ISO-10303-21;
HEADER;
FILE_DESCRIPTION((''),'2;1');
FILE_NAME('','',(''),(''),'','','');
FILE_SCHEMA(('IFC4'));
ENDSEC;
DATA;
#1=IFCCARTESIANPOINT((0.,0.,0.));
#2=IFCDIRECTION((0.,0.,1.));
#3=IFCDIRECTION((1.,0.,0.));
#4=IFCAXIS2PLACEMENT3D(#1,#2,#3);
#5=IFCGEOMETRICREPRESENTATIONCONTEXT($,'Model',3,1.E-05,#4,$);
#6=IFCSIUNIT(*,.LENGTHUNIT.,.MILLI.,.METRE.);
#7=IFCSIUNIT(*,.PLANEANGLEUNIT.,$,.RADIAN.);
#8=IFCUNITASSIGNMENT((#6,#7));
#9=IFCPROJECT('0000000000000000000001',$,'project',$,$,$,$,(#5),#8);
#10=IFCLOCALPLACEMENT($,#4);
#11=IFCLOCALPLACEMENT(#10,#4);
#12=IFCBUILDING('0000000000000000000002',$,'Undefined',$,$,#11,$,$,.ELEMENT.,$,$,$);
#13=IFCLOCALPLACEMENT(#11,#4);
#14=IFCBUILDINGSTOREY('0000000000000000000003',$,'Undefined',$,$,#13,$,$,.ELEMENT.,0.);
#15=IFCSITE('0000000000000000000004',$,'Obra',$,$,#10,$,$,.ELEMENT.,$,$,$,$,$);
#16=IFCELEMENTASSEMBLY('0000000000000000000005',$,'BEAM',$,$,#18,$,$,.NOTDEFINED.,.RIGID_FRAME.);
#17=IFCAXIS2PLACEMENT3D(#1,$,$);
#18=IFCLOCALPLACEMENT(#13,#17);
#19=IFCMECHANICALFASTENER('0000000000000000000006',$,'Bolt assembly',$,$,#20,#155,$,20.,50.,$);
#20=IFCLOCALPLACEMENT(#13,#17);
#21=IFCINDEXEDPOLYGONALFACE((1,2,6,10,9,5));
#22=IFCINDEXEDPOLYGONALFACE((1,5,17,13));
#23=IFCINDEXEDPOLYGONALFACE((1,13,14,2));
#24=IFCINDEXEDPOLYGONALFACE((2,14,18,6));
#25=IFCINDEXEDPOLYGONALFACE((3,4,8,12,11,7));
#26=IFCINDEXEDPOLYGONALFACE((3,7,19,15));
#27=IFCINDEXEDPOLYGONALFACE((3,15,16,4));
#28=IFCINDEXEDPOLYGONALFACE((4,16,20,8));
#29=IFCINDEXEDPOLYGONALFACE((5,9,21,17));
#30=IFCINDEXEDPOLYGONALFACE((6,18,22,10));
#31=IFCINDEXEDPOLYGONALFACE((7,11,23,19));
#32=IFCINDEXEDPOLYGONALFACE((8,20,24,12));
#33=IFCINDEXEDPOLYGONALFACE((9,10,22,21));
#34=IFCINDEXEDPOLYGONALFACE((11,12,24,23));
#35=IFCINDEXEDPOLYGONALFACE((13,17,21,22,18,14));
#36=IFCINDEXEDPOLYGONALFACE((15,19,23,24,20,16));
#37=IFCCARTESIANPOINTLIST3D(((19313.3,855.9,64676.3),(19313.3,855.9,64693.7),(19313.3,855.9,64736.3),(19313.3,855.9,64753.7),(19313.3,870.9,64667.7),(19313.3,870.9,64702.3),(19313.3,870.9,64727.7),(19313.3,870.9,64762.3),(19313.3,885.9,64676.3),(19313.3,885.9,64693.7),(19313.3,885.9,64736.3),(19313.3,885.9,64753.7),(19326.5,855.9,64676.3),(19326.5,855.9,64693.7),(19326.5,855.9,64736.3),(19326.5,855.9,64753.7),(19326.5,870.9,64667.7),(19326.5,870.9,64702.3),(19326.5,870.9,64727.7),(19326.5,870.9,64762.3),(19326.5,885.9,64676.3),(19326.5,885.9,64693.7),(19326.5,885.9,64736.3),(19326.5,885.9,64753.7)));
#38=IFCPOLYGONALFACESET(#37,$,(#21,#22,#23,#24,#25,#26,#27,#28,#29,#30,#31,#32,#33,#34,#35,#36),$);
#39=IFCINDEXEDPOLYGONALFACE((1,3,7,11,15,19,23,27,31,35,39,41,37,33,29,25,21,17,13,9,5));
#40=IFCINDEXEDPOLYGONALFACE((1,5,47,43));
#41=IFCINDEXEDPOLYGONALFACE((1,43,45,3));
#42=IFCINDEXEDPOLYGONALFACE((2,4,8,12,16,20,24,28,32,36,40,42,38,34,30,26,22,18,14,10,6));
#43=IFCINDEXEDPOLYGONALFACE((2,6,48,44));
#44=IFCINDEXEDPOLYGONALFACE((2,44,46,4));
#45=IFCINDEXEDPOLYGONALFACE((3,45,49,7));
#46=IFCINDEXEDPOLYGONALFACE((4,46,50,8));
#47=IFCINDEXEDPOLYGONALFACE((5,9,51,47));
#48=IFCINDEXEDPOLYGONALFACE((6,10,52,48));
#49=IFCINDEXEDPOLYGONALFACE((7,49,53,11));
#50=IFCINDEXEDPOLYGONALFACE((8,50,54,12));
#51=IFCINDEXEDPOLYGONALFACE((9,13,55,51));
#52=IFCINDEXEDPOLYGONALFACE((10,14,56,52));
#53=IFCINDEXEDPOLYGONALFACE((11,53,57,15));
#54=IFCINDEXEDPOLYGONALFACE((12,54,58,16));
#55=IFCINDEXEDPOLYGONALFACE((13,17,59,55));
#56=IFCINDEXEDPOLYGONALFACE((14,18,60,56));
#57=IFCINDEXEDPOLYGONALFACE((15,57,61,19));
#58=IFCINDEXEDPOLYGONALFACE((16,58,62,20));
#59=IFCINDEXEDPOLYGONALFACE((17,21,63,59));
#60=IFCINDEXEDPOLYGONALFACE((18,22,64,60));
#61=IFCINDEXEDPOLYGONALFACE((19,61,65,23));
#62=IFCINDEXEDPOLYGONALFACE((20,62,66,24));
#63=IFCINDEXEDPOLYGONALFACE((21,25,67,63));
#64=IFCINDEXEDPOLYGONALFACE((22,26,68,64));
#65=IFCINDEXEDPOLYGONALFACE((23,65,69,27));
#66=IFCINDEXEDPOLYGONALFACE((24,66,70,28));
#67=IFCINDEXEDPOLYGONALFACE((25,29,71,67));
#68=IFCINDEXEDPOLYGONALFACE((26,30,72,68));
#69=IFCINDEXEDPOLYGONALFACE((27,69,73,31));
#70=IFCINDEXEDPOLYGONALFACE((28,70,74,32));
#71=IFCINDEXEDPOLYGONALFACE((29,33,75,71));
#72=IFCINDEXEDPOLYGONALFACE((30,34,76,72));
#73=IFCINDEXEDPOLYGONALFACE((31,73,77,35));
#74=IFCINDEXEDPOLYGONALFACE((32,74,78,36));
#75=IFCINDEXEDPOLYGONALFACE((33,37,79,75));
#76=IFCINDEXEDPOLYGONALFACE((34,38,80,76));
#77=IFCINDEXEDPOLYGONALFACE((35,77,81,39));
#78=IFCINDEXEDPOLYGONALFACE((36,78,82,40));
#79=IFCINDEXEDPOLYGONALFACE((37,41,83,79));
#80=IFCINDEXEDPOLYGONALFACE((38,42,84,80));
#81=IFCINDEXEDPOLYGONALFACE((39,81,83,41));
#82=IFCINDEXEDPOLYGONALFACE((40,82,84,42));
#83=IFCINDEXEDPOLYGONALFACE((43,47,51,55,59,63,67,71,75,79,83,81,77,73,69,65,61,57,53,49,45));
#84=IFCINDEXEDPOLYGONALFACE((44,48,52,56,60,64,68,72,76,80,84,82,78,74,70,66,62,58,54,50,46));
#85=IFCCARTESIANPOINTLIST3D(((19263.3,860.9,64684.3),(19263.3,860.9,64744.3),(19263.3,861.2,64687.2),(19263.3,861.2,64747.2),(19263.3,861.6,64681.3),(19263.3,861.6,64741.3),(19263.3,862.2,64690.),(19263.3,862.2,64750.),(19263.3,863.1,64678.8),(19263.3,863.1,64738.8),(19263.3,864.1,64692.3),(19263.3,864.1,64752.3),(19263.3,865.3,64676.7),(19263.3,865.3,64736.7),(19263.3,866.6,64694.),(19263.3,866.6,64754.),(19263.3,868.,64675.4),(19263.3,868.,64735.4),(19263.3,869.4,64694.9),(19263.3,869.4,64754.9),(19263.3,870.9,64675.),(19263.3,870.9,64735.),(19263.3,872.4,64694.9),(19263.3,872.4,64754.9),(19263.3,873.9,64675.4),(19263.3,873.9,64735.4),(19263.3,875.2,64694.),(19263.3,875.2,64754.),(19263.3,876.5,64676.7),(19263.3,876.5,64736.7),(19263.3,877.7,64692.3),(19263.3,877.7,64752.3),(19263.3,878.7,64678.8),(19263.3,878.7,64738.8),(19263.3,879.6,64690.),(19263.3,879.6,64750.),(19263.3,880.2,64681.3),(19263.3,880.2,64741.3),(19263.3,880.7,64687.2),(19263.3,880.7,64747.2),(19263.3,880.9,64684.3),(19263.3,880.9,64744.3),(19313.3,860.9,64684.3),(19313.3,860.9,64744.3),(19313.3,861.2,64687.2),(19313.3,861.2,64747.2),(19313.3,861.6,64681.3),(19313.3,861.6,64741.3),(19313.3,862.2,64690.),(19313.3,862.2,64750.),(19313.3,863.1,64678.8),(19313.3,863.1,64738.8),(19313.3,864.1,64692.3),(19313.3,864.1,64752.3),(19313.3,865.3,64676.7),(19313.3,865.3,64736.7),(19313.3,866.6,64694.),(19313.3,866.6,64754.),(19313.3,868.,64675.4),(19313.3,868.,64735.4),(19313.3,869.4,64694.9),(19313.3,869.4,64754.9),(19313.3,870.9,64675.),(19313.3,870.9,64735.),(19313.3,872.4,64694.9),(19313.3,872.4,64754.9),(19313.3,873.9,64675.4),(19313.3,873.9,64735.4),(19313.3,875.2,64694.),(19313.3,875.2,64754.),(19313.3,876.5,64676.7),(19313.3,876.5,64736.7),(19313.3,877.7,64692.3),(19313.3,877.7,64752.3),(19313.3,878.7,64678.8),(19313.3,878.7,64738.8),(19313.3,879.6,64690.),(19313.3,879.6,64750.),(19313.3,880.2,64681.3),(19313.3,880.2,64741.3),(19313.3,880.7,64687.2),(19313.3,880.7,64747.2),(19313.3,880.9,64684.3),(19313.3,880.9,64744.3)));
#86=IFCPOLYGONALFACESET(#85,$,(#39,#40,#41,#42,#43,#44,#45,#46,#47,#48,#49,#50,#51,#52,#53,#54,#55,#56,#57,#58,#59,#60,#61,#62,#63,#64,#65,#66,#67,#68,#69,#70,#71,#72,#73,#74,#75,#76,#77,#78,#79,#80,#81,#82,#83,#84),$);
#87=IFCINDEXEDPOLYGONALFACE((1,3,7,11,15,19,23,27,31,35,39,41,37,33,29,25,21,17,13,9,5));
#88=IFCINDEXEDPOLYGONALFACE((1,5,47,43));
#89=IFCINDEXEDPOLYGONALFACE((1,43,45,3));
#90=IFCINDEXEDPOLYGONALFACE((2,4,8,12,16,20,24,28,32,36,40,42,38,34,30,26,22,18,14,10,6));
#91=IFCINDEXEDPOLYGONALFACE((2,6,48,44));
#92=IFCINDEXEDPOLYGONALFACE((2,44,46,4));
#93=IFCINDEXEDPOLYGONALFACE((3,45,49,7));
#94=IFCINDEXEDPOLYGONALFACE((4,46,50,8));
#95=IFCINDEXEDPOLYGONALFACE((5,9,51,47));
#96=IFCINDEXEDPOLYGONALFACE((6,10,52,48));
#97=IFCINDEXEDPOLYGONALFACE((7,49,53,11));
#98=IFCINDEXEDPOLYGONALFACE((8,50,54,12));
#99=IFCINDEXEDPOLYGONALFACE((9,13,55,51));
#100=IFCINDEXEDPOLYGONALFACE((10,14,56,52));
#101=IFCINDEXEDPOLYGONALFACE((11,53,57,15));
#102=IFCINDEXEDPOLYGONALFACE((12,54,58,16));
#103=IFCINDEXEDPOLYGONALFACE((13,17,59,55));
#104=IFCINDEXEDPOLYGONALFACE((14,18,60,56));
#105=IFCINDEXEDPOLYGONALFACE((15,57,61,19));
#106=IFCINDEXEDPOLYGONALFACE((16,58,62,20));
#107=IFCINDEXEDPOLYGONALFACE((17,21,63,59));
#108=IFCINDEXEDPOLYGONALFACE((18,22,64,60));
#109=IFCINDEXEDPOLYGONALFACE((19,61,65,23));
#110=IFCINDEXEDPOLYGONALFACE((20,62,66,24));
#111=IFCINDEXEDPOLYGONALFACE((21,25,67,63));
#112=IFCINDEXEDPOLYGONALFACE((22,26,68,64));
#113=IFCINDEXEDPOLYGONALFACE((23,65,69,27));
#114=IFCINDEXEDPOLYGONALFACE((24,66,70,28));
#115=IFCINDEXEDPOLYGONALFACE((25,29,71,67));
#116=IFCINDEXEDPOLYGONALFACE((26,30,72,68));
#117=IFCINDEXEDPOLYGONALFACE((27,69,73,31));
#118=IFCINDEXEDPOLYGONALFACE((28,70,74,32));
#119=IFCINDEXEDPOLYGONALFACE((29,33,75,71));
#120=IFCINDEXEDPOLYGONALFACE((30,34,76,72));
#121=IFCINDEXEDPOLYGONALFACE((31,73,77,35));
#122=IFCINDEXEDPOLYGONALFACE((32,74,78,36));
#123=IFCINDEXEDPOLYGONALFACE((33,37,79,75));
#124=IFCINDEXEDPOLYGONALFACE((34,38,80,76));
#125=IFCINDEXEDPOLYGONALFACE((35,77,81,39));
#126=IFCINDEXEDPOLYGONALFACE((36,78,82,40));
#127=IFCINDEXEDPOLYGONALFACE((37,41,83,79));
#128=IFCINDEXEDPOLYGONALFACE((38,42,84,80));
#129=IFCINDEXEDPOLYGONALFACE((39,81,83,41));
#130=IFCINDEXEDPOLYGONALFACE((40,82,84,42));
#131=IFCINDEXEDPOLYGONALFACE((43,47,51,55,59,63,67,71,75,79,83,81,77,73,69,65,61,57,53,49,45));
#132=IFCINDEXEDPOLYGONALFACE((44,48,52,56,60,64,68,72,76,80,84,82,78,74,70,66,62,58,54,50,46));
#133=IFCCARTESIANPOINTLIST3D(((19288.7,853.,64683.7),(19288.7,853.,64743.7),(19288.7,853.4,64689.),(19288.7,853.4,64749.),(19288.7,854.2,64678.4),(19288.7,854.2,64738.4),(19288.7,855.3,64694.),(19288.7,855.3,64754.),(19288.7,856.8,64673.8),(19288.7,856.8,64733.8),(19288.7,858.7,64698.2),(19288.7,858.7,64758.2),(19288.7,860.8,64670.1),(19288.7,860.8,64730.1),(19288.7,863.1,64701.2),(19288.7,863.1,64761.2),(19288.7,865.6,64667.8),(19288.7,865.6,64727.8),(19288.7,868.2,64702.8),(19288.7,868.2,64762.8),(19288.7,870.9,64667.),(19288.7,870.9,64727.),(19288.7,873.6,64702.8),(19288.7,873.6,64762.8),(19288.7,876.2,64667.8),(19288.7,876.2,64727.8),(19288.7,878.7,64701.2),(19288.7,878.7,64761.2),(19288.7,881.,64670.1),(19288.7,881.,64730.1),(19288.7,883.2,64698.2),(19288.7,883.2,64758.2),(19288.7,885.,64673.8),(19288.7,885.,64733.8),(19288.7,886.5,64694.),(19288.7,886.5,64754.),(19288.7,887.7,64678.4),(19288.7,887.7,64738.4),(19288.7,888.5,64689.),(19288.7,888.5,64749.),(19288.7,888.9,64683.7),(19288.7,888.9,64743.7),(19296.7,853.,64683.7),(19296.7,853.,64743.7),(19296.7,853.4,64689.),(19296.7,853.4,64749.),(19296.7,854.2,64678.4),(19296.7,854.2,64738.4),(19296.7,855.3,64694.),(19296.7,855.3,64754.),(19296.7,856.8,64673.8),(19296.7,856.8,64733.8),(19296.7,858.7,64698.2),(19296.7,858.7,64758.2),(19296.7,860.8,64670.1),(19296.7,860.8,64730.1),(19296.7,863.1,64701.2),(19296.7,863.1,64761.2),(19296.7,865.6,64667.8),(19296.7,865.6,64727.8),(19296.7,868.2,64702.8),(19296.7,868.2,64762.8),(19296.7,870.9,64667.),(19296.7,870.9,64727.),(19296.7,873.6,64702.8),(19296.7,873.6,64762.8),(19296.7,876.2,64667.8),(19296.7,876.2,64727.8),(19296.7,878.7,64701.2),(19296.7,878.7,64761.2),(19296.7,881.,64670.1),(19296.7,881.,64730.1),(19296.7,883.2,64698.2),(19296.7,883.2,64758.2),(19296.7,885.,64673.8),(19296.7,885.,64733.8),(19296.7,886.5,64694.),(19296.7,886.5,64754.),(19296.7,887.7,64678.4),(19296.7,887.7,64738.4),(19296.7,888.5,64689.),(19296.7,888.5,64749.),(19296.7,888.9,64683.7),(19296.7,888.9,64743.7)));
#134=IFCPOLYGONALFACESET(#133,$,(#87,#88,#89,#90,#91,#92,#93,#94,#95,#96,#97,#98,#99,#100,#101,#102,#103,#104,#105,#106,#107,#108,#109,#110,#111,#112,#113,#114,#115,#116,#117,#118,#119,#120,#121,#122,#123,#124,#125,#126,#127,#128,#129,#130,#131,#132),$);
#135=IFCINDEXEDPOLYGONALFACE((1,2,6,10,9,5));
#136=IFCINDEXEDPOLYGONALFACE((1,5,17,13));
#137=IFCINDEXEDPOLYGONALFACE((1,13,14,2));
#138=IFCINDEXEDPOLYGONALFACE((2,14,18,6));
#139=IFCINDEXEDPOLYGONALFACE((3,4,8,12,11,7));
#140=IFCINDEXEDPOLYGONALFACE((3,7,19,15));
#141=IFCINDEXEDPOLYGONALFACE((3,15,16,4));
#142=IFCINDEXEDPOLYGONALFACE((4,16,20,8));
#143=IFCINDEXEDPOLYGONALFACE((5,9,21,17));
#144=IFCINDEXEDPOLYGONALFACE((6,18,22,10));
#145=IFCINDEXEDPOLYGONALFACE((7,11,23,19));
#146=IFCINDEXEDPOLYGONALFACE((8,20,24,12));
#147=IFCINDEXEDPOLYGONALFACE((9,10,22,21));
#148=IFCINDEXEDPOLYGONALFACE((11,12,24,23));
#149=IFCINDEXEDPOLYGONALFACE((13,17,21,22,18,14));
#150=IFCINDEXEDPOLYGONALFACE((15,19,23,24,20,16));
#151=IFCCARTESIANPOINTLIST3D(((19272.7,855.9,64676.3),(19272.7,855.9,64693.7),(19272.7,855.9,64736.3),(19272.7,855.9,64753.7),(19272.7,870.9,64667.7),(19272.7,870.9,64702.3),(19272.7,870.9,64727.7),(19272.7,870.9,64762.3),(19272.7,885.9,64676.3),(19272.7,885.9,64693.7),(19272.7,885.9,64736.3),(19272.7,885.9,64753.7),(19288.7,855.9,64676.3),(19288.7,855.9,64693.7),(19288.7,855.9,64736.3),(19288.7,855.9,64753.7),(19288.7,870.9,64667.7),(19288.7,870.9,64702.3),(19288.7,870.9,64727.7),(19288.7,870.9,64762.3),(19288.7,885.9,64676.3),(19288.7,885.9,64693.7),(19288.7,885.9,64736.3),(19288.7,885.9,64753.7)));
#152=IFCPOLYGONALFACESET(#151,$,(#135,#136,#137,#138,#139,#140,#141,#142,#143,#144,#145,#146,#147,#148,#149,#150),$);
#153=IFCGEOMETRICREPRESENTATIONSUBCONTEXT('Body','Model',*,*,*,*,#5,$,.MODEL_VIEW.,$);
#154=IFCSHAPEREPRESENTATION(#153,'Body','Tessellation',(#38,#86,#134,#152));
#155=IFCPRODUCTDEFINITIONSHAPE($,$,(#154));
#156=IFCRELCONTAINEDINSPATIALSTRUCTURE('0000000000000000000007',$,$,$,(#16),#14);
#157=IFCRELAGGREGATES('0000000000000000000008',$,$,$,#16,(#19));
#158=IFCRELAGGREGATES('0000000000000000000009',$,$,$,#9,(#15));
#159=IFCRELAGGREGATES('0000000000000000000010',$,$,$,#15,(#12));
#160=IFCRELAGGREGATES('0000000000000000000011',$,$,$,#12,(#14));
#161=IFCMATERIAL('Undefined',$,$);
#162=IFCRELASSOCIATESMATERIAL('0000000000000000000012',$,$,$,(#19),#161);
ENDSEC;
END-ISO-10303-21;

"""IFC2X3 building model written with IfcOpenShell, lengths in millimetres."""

from ifc_helpers import new_model, si_unit, frame, origin_with_axes, origin_2d_with_axis, place, context, subcontext, project, spatial, polyline, circle, outline, extrude, source, transform, mapped, material, element, aggregate, save


model = new_model("IFC2X3")

# Units and contexts
model_context = context("Model", 3, precision=1e-05, world=origin_with_axes())
body_context = subcontext(model_context, "Body", "Model", "MODEL_VIEW")
ifc_project = project(units=[si_unit("LENGTHUNIT", "METRE", prefix="MILLI"), si_unit("PLANEANGLEUNIT", "RADIAN")], contexts=[model_context])

# Site, building, storey
site_placement = place(None, origin_with_axes())
site = spatial("IfcSite", under=ifc_project, at=site_placement, Name="Obra", CompositionType="ELEMENT")
building_placement = place(site_placement, origin_with_axes())
building = spatial("IfcBuilding", under=site, at=building_placement, Name="Undefined", CompositionType="ELEMENT")
storey_placement = place(building_placement, origin_with_axes())
storey = spatial("IfcBuildingStorey", under=building, at=storey_placement, Name="Undefined", CompositionType="ELEMENT", Elevation=0.0)

# Shared definitions
ifc_material = material(Name="Undefined")
shared_shape_1 = source(origin_with_axes(), body_context, "Body", "SweptSolid", [
    extrude(outline(polyline([(17.3, 0.0), (8.7, 15.0), (-8.7, 15.0), (-17.3, 0.0), (-8.7, -15.0), (8.7, -15.0), (17.3, 0.0)])), frame((0.0, -26.5, 0.0), z_axis=(0.0, 1.0, 0.0), x_axis=(1.0, 0.0, 0.0)), (0.0, 0.0, 1.0), 13.2),
    extrude(circle(Radius=10.0, at=origin_2d_with_axis()), frame((0.0, -13.3, 0.0), z_axis=(0.0, 1.0, 0.0), x_axis=(1.0, 0.0, 0.0)), (0.0, 0.0, 1.0), 50.0),
    extrude(circle(Radius=18.0, at=origin_2d_with_axis()), frame((0.0, 3.3, 0.0), z_axis=(0.0, 1.0, 0.0), x_axis=(1.0, 0.0, 0.0)), (0.0, 0.0, 1.0), 8.0),
    extrude(outline(polyline([(17.3, 0.0), (8.7, 15.0), (-8.7, 15.0), (-17.3, 0.0), (-8.7, -15.0), (8.7, -15.0), (17.3, 0.0)])), frame((0.0, 11.3, 0.0), z_axis=(0.0, 1.0, 0.0), x_axis=(1.0, 0.0, 0.0)), (0.0, 0.0, 1.0), 16.0),
])

# Element assembly
assembly_1_placement = place(storey_placement, origin_with_axes())
assembly_1 = element("IfcElementAssembly", 1, at=assembly_1_placement, inside=storey, Name="BEAM", AssemblyPlace="NOTDEFINED", PredefinedType="RIGID_FRAME")

# Mechanical fastener
mechanical_fastener_1_placement = place(assembly_1_placement, frame((19300.0, 830.9, 64850.0), z_axis=(0.0, 1.0, 0.0), x_axis=(0.0, 0.0, -1.0)))
mechanical_fastener_1 = element("IfcMechanicalFastener", 2, at=mechanical_fastener_1_placement, material=ifc_material, Name="Bolt assembly", NominalDiameter=20.0, NominalLength=50.0, context=body_context, shape_type="MappedRepresentation", body=[
    mapped(shared_shape_1, transform((105.0, 0.0, 40.0))),
    mapped(shared_shape_1, transform((165.0, 0.0, 40.0))),
])
aggregate(assembly_1, [mechanical_fastener_1])

save(model, "model.ifc")
